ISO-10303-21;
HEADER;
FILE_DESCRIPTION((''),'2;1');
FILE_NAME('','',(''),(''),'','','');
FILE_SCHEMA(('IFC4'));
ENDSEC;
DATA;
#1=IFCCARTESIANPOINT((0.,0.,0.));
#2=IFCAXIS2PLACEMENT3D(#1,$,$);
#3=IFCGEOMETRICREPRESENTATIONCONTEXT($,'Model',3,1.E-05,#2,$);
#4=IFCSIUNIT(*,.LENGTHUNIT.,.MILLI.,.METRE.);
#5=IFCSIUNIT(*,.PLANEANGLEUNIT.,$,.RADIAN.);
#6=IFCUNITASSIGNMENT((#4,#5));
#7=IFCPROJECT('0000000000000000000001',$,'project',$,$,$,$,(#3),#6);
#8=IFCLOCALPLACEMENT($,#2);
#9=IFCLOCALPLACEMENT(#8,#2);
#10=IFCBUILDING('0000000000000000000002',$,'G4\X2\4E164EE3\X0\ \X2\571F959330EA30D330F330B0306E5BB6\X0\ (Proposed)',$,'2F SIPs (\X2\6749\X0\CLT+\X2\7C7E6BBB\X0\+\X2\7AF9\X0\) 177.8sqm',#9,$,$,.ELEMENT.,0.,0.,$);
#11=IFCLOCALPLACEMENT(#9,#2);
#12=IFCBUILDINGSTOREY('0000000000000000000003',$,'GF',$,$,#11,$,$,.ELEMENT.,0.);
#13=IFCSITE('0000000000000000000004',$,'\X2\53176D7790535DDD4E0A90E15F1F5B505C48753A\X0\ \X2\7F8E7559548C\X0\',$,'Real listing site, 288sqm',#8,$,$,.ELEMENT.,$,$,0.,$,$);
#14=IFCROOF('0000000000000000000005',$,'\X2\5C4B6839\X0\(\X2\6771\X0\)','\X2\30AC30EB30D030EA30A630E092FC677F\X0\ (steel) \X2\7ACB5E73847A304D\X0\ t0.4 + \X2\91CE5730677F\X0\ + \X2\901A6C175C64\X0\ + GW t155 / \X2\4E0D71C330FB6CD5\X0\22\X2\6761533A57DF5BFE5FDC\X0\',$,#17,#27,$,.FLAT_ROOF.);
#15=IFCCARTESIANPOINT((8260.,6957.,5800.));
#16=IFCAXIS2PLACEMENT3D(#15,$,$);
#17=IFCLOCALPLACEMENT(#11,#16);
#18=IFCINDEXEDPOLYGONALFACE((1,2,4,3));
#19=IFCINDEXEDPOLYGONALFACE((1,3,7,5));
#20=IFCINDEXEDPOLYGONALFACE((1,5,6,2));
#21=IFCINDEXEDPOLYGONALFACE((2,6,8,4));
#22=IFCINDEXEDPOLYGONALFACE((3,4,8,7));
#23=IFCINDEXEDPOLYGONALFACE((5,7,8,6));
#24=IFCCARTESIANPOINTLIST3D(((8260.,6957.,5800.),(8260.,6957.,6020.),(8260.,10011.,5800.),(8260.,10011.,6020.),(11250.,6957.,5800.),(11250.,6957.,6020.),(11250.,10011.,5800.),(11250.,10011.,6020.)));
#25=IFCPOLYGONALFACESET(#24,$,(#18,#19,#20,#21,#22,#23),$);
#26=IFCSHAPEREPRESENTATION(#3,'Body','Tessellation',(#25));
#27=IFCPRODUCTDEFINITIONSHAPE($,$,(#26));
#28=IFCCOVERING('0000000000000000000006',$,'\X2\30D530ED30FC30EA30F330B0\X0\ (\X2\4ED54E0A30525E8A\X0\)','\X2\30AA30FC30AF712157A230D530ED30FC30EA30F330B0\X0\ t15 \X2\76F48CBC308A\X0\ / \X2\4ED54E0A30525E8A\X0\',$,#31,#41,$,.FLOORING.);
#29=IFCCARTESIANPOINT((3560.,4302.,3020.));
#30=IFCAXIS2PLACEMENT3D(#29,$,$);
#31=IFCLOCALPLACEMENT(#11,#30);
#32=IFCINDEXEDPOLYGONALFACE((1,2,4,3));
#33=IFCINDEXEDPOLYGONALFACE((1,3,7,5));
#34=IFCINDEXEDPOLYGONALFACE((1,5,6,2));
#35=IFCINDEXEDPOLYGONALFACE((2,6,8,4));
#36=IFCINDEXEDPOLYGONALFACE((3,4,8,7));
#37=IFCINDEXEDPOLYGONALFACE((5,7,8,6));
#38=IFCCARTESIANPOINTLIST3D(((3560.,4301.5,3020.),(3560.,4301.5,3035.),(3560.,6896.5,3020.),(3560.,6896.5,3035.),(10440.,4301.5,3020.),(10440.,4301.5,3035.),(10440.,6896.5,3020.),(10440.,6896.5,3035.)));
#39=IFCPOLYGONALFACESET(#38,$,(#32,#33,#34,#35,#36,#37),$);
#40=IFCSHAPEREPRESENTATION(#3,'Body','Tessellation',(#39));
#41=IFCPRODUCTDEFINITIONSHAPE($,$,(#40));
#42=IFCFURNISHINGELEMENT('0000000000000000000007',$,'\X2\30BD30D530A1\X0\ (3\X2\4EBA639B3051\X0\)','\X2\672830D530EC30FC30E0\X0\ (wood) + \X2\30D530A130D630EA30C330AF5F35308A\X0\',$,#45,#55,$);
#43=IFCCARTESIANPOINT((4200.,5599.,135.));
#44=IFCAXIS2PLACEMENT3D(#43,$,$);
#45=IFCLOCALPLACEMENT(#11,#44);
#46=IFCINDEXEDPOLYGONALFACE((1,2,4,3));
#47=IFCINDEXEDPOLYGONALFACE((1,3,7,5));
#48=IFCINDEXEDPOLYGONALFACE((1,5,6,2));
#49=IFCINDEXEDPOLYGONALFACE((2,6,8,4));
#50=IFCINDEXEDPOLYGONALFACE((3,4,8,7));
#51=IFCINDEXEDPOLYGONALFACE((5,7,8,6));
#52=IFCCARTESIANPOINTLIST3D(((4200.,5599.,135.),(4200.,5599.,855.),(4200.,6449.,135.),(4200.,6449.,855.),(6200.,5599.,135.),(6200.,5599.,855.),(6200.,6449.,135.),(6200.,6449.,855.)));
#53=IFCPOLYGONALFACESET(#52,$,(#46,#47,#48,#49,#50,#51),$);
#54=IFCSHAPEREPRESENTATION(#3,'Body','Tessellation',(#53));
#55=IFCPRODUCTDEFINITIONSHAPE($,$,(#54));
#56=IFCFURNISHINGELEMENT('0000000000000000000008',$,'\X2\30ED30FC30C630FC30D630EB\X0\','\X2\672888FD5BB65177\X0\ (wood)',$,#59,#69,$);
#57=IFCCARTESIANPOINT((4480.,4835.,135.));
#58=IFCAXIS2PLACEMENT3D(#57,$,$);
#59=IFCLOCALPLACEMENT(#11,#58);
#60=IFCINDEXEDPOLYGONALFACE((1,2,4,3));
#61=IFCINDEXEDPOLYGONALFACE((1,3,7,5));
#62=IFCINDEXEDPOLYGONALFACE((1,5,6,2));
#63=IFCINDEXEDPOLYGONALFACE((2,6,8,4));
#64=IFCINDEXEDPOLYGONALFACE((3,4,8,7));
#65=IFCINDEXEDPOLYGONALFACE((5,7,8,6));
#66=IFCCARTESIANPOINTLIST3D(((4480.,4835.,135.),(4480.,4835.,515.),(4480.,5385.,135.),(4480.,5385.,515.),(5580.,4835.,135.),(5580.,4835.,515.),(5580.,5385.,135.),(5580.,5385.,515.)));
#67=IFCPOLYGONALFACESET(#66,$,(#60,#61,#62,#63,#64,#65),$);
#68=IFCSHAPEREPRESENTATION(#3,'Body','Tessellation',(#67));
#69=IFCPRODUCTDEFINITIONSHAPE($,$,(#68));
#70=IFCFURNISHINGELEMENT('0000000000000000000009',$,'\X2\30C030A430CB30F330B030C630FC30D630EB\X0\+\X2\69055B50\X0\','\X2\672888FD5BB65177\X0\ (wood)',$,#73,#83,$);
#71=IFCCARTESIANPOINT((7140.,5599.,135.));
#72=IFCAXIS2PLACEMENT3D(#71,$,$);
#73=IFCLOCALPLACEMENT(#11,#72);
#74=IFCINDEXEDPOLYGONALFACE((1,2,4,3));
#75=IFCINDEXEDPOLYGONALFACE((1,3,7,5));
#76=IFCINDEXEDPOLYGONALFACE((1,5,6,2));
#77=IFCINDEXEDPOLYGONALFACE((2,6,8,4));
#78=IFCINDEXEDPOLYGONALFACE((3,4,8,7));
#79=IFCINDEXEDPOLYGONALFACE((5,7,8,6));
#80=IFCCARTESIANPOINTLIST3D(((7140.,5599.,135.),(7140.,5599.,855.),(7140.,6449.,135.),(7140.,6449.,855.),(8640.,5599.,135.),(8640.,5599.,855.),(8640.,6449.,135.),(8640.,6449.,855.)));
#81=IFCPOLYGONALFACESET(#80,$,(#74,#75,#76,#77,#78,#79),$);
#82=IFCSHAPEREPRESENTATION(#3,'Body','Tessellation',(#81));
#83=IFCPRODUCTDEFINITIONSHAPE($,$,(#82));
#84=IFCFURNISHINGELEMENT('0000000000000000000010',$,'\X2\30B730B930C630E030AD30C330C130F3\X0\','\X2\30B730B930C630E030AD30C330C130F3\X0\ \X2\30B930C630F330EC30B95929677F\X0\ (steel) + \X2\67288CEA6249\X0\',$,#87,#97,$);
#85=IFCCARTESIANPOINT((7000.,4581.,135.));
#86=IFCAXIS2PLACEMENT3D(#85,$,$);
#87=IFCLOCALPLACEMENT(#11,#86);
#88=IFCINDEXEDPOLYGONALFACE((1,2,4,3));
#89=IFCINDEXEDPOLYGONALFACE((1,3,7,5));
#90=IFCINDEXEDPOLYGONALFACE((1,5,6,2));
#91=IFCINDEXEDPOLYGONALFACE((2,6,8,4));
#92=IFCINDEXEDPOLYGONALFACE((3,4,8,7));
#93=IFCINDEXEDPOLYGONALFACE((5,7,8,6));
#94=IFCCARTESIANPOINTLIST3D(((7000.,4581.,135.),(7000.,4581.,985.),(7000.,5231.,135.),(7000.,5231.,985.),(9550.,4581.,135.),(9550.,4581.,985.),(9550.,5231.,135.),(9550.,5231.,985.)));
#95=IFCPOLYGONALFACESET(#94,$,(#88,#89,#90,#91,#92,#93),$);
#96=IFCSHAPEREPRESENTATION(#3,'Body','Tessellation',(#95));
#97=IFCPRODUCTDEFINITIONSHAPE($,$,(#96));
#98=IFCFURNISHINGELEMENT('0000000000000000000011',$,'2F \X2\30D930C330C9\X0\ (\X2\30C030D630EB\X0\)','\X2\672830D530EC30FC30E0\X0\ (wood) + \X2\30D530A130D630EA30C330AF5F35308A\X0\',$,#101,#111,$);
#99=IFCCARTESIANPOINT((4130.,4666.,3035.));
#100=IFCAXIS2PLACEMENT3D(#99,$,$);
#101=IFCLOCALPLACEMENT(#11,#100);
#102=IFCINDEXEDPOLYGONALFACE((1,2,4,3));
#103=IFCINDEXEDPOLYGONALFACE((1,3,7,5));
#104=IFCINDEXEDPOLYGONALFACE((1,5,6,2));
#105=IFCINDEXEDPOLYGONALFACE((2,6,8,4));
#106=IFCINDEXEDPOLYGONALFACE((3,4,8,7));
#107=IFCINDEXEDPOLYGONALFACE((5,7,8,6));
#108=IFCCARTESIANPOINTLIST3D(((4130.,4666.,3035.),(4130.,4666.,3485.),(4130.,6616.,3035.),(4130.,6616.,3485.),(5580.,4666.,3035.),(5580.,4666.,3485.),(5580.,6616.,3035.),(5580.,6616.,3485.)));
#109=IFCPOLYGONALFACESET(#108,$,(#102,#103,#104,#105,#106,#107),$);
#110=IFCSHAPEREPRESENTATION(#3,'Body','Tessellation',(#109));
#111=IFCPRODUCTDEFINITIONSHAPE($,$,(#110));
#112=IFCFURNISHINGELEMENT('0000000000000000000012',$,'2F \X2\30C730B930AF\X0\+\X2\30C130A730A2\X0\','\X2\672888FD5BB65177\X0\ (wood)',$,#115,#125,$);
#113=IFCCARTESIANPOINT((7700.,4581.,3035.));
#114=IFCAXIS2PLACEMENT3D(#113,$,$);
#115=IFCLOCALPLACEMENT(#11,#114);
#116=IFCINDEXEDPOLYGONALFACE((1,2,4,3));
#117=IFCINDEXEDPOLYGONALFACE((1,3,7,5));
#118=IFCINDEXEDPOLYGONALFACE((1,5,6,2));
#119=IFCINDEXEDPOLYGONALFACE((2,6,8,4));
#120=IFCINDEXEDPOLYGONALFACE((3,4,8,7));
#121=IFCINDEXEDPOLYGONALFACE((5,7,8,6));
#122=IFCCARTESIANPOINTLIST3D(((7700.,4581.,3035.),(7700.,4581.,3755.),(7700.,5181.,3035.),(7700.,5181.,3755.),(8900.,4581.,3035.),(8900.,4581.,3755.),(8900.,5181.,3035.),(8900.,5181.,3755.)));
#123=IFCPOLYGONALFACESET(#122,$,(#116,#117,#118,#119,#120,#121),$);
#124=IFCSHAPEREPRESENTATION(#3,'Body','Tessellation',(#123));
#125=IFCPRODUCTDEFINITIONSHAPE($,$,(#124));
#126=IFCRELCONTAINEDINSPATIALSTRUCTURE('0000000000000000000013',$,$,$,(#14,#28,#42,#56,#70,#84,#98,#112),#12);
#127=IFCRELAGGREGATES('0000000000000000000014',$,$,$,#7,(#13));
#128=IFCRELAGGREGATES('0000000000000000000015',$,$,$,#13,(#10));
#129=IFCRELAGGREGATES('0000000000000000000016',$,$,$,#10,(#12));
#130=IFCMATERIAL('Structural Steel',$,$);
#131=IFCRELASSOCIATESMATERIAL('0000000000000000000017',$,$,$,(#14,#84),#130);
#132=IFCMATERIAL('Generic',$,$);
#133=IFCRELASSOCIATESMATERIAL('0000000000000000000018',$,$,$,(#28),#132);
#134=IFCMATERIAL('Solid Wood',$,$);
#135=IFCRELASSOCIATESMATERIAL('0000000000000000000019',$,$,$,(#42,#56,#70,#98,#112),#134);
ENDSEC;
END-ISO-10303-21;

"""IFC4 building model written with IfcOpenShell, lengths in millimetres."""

from ifc_helpers import new_model, si_unit, frame, frame_2d, origin, place, context, project, spatial, rectangle, extrude, material, element, save


model = new_model("IFC4")

# Units and contexts
model_context = context("Model", 3, precision=1e-05, world=origin())
ifc_project = project(units=[si_unit("LENGTHUNIT", "METRE", prefix="MILLI"), si_unit("PLANEANGLEUNIT", "RADIAN")], contexts=[model_context])

# Site, building, storey
site_placement = place(None, origin())
site = spatial("IfcSite", under=ifc_project, at=site_placement, Name="北海道川上郡弟子屈町 美留和", ObjectType="Real listing site, 288sqm", CompositionType="ELEMENT", RefElevation=0.0)
building_placement = place(site_placement, origin())
building = spatial("IfcBuilding", under=site, at=building_placement, Name="G4世代 土間リビングの家 (Proposed)", ObjectType="2F SIPs (杉CLT+籾殻+竹) 177.8sqm", CompositionType="ELEMENT", ElevationOfRefHeight=0.0, ElevationOfTerrain=0.0)
storey_placement = place(building_placement, origin())
storey = spatial("IfcBuildingStorey", under=building, at=storey_placement, Name="GF", CompositionType="ELEMENT", Elevation=0.0)

# Shared definitions
ifc_material_1 = material(Name="Solid Wood")

# Shared definitions
ifc_material_2 = material(Name="Generic")

# Roof
ifc_material_3 = material(Name="Structural Steel")
roof_placement = place(storey_placement, frame((8260.0, 6957.0, 5800.0)))
element("IfcRoof", 1, at=roof_placement, inside=storey, material=ifc_material_3, Name="屋根(東)", Description="ガルバリウム鋼板 (steel) 立平葺き t0.4 + 野地板 + 通気層 + GW t155 / 不燃・法22条区域対応", PredefinedType="FLAT_ROOF", context=model_context, shape_type="SweptSolid", body=[
    extrude(rectangle(XDim=2990.0, YDim=3054.0, at=frame_2d((1495.0, 1527.0))), frame((8260.0, 6957.0, 5800.0)), (0.0, 0.0, 1.0), 220.0),
])

# Covering
covering_placement = place(storey_placement, frame((3560.0, 4302.0, 3020.0)))
element("IfcCovering", 2, at=covering_placement, inside=storey, material=ifc_material_2, Name="フローリング (仕上げ床)", Description="オーク無垢フローリング t15 直貼り / 仕上げ床", PredefinedType="FLOORING", context=model_context, shape_type="SweptSolid", body=[
    extrude(rectangle(XDim=6880.0, YDim=2595.0, at=frame_2d((3440.0, 1297.0))), frame((3560.0, 4302.0, 3020.0)), (0.0, 0.0, 1.0), 15.0),
])

# Furnishing elements
furnishing_1_placement = place(storey_placement, frame((4200.0, 5599.0, 135.0)))
element("IfcFurnishingElement", 3, at=furnishing_1_placement, inside=storey, material=ifc_material_1, Name="ソファ (3人掛け)", Description="木フレーム (wood) + ファブリック張り", context=model_context, shape_type="SweptSolid", body=[
    extrude(rectangle(XDim=2000.0, YDim=850.0, at=frame_2d((1000.0, 425.0))), frame((4200.0, 5599.0, 135.0)), (0.0, 0.0, 1.0), 720.0),
])
furnishing_2_placement = place(storey_placement, frame((4480.0, 4835.0, 135.0)))
element("IfcFurnishingElement", 4, at=furnishing_2_placement, inside=storey, material=ifc_material_1, Name="ローテーブル", Description="木製家具 (wood)", context=model_context, shape_type="SweptSolid", body=[
    extrude(rectangle(XDim=1100.0, YDim=550.0, at=frame_2d((550.0, 275.0))), frame((4480.0, 4835.0, 135.0)), (0.0, 0.0, 1.0), 380.0),
])
furnishing_3_placement = place(storey_placement, frame((7140.0, 5599.0, 135.0)))
element("IfcFurnishingElement", 5, at=furnishing_3_placement, inside=storey, material=ifc_material_1, Name="ダイニングテーブル+椅子", Description="木製家具 (wood)", context=model_context, shape_type="SweptSolid", body=[
    extrude(rectangle(XDim=1500.0, YDim=850.0, at=frame_2d((750.0, 425.0))), frame((7140.0, 5599.0, 135.0)), (0.0, 0.0, 1.0), 720.0),
])
furnishing_4_placement = place(storey_placement, frame((7000.0, 4581.0, 135.0)))
element("IfcFurnishingElement", 6, at=furnishing_4_placement, inside=storey, material=ifc_material_3, Name="システムキッチン", Description="システムキッチン ステンレス天板 (steel) + 木質扉", context=model_context, shape_type="SweptSolid", body=[
    extrude(rectangle(XDim=2550.0, YDim=650.0, at=frame_2d((1275.0, 325.0))), frame((7000.0, 4581.0, 135.0)), (0.0, 0.0, 1.0), 850.0),
])
furnishing_5_placement = place(storey_placement, frame((4130.0, 4666.0, 3035.0)))
element("IfcFurnishingElement", 7, at=furnishing_5_placement, inside=storey, material=ifc_material_1, Name="2F ベッド (ダブル)", Description="木フレーム (wood) + ファブリック張り", context=model_context, shape_type="SweptSolid", body=[
    extrude(rectangle(XDim=1450.0, YDim=1950.0, at=frame_2d((725.0, 975.0))), frame((4130.0, 4666.0, 3035.0)), (0.0, 0.0, 1.0), 450.0),
])
furnishing_6_placement = place(storey_placement, frame((7700.0, 4581.0, 3035.0)))
element("IfcFurnishingElement", 8, at=furnishing_6_placement, inside=storey, material=ifc_material_1, Name="2F デスク+チェア", Description="木製家具 (wood)", context=model_context, shape_type="SweptSolid", body=[
    extrude(rectangle(XDim=1200.0, YDim=600.0, at=frame_2d((600.0, 300.0))), frame((7700.0, 4581.0, 3035.0)), (0.0, 0.0, 1.0), 720.0),
])

save(model, "model.ifc")
